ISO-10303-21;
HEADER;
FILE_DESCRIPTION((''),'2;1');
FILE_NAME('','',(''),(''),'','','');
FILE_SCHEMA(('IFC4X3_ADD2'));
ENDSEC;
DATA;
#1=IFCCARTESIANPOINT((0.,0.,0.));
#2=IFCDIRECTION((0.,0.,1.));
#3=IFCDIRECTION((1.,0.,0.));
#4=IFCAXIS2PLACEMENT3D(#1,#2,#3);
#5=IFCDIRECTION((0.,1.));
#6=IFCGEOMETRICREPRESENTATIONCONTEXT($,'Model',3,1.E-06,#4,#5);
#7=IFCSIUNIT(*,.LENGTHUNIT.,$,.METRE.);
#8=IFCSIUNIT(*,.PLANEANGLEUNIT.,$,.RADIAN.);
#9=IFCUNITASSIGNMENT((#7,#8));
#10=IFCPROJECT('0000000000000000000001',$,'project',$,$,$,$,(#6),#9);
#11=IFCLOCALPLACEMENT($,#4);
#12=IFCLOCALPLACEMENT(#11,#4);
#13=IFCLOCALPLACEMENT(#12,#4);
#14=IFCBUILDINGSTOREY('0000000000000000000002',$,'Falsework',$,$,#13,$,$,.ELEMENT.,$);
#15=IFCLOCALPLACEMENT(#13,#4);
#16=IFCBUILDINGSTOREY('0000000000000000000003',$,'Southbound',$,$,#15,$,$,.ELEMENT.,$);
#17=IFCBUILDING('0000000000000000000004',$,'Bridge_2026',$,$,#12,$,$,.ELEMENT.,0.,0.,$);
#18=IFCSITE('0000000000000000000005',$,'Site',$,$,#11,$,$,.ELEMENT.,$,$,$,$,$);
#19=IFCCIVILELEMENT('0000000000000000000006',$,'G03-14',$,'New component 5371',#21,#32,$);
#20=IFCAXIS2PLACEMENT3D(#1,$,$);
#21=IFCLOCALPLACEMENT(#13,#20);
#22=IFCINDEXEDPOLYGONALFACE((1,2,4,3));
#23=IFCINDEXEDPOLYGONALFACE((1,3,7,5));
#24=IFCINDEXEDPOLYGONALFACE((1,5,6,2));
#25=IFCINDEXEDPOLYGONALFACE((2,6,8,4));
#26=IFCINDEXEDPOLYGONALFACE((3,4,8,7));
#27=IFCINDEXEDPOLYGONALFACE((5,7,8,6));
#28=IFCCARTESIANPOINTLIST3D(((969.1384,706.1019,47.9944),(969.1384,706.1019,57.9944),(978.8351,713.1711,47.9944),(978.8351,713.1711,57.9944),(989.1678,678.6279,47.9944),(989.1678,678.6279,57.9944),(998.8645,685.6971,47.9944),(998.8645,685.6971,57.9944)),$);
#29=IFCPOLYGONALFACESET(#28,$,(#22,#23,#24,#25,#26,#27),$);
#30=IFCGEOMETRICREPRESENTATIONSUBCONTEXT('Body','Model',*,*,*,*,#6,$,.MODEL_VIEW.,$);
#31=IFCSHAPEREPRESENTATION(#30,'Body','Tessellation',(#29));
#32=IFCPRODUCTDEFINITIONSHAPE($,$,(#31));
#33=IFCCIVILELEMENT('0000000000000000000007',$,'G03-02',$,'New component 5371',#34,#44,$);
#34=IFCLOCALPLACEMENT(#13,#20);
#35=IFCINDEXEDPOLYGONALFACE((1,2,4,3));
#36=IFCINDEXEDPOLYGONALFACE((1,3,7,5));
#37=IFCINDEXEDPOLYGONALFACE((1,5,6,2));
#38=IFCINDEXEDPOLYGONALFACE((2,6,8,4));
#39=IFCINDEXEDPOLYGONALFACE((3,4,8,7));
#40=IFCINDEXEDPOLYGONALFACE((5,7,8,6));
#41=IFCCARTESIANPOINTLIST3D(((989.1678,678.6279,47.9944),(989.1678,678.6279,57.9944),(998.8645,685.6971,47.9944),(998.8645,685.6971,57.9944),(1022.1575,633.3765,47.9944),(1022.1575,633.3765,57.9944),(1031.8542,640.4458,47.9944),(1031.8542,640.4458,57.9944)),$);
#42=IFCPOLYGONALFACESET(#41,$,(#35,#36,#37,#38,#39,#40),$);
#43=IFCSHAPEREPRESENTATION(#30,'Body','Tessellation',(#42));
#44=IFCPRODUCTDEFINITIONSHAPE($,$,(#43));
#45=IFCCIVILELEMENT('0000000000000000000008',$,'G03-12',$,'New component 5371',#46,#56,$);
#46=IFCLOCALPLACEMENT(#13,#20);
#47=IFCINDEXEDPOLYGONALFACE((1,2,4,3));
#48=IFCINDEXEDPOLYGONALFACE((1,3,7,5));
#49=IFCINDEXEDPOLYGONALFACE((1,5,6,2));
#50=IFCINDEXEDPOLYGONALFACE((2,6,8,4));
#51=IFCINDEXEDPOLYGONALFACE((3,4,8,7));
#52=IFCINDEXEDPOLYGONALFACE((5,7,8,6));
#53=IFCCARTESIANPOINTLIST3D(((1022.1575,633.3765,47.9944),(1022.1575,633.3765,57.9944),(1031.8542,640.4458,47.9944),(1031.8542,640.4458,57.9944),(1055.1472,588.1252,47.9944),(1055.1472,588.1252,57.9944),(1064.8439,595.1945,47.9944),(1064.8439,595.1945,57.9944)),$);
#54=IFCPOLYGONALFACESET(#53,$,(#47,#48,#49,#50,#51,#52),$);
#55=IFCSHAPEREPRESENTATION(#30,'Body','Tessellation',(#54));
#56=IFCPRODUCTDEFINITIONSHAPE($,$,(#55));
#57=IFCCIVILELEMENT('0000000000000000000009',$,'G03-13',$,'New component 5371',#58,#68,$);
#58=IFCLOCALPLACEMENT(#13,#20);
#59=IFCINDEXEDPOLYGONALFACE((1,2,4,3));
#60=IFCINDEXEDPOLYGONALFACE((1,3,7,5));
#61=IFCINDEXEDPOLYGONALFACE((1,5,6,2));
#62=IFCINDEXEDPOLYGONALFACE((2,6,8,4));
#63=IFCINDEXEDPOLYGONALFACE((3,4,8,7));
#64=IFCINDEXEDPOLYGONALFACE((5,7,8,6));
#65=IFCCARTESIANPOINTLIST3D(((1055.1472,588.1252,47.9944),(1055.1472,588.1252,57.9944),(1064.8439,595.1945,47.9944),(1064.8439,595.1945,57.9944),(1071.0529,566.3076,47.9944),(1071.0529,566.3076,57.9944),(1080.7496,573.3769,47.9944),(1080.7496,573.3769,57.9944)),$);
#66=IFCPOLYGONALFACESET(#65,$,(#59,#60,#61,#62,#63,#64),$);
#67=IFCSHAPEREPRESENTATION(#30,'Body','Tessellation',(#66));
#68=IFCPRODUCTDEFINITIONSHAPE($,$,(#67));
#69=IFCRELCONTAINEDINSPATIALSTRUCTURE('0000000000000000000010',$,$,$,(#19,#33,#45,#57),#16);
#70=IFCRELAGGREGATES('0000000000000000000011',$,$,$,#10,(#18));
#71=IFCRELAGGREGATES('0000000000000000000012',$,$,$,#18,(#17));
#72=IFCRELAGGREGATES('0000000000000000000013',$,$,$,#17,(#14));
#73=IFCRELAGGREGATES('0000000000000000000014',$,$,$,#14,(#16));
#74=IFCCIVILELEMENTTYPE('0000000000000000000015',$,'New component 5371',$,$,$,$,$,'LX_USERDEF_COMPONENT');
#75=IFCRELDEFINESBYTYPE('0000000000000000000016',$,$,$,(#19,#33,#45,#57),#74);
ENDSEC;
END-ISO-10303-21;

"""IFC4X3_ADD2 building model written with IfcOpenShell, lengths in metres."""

from ifc_helpers import new_model, si_unit, direction, frame, frame_2d, origin_with_axes, place, context, subcontext, project, spatial, rectangle, extrude, type_object, element, save


model = new_model("IFC4X3_ADD2")

# Units and contexts
model_context = context("Model", 3, precision=1e-06, world=origin_with_axes(), true_north=direction((0.0, 1.0)))
body_context = subcontext(model_context, "Body", "Model", "MODEL_VIEW")
ifc_project = project(units=[si_unit("LENGTHUNIT", "METRE"), si_unit("PLANEANGLEUNIT", "RADIAN")], contexts=[model_context])

# Site, building, storeys
site_placement = place(None, origin_with_axes())
site = spatial("IfcSite", under=ifc_project, at=site_placement, Name="Site", CompositionType="ELEMENT")
building_placement = place(site_placement, origin_with_axes())
building = spatial("IfcBuilding", under=site, at=building_placement, Name="Bridge_2026", CompositionType="ELEMENT", ElevationOfRefHeight=0.0, ElevationOfTerrain=0.0)
storey_1_placement = place(building_placement, origin_with_axes())
storey_1 = spatial("IfcBuildingStorey", under=building, at=storey_1_placement, Name="Falsework", CompositionType="ELEMENT")
storey_2_placement = place(storey_1_placement, origin_with_axes())
storey_2 = spatial("IfcBuildingStorey", under=storey_1, at=storey_2_placement, Name="Southbound", CompositionType="ELEMENT")

# Civil elements
civil_element_type = type_object("IfcCivilElementType", Name="New component 5371", ElementType="LX_USERDEF_COMPONENT")
civil_element_1_placement = place(storey_2_placement, frame((989.1678, 678.6279, 47.9944), z_axis=(0.0, 0.0, 1.0), x_axis=(0.808059, 0.589101, 0.0)))
element("IfcCivilElement", 1, at=civil_element_1_placement, inside=storey_2, type_object=civil_element_type, Name="G03-14", ObjectType="New component 5371", context=body_context, shape_type="SweptSolid", body=[
    extrude(rectangle(XDim=12.0, YDim=34.0, at=frame_2d((6.0, 17.0), x_axis=(1.0, 0.0))), origin_with_axes(), (0.0, 0.0, 1.0), 10.0),
])
for number, where, z_axis, x_axis, name in (
    (2, (1022.1575, 633.3765, 47.9944), (0.0, 0.0, 1.0), (0.808059, 0.589101, 0.0), "G03-02"),
    (3, (1055.1472, 588.1252, 47.9944), (0.0, 0.0, 1.0), (0.808059, 0.589101, 0.0), "G03-12"),
):
    element("IfcCivilElement", number, at=place(storey_2_placement, frame(where, z_axis=z_axis, x_axis=x_axis)), inside=storey_2, type_object=civil_element_type, Name=name, ObjectType="New component 5371", context=body_context, shape_type="SweptSolid", body=[
        extrude(rectangle(XDim=12.0, YDim=56.0, at=frame_2d((6.0, 28.0), x_axis=(1.0, 0.0))), origin_with_axes(), (0.0, 0.0, 1.0), 10.0),
    ])
civil_element_2_placement = place(storey_2_placement, frame((1071.0529, 566.3076, 47.9944), z_axis=(0.0, 0.0, 1.0), x_axis=(0.808059, 0.589101, 0.0)))
element("IfcCivilElement", 4, at=civil_element_2_placement, inside=storey_2, type_object=civil_element_type, Name="G03-13", ObjectType="New component 5371", context=body_context, shape_type="SweptSolid", body=[
    extrude(rectangle(XDim=12.0, YDim=27.0, at=frame_2d((6.0, 13.5), x_axis=(1.0, 0.0))), origin_with_axes(), (0.0, 0.0, 1.0), 10.0),
])

save(model, "model.ifc")
